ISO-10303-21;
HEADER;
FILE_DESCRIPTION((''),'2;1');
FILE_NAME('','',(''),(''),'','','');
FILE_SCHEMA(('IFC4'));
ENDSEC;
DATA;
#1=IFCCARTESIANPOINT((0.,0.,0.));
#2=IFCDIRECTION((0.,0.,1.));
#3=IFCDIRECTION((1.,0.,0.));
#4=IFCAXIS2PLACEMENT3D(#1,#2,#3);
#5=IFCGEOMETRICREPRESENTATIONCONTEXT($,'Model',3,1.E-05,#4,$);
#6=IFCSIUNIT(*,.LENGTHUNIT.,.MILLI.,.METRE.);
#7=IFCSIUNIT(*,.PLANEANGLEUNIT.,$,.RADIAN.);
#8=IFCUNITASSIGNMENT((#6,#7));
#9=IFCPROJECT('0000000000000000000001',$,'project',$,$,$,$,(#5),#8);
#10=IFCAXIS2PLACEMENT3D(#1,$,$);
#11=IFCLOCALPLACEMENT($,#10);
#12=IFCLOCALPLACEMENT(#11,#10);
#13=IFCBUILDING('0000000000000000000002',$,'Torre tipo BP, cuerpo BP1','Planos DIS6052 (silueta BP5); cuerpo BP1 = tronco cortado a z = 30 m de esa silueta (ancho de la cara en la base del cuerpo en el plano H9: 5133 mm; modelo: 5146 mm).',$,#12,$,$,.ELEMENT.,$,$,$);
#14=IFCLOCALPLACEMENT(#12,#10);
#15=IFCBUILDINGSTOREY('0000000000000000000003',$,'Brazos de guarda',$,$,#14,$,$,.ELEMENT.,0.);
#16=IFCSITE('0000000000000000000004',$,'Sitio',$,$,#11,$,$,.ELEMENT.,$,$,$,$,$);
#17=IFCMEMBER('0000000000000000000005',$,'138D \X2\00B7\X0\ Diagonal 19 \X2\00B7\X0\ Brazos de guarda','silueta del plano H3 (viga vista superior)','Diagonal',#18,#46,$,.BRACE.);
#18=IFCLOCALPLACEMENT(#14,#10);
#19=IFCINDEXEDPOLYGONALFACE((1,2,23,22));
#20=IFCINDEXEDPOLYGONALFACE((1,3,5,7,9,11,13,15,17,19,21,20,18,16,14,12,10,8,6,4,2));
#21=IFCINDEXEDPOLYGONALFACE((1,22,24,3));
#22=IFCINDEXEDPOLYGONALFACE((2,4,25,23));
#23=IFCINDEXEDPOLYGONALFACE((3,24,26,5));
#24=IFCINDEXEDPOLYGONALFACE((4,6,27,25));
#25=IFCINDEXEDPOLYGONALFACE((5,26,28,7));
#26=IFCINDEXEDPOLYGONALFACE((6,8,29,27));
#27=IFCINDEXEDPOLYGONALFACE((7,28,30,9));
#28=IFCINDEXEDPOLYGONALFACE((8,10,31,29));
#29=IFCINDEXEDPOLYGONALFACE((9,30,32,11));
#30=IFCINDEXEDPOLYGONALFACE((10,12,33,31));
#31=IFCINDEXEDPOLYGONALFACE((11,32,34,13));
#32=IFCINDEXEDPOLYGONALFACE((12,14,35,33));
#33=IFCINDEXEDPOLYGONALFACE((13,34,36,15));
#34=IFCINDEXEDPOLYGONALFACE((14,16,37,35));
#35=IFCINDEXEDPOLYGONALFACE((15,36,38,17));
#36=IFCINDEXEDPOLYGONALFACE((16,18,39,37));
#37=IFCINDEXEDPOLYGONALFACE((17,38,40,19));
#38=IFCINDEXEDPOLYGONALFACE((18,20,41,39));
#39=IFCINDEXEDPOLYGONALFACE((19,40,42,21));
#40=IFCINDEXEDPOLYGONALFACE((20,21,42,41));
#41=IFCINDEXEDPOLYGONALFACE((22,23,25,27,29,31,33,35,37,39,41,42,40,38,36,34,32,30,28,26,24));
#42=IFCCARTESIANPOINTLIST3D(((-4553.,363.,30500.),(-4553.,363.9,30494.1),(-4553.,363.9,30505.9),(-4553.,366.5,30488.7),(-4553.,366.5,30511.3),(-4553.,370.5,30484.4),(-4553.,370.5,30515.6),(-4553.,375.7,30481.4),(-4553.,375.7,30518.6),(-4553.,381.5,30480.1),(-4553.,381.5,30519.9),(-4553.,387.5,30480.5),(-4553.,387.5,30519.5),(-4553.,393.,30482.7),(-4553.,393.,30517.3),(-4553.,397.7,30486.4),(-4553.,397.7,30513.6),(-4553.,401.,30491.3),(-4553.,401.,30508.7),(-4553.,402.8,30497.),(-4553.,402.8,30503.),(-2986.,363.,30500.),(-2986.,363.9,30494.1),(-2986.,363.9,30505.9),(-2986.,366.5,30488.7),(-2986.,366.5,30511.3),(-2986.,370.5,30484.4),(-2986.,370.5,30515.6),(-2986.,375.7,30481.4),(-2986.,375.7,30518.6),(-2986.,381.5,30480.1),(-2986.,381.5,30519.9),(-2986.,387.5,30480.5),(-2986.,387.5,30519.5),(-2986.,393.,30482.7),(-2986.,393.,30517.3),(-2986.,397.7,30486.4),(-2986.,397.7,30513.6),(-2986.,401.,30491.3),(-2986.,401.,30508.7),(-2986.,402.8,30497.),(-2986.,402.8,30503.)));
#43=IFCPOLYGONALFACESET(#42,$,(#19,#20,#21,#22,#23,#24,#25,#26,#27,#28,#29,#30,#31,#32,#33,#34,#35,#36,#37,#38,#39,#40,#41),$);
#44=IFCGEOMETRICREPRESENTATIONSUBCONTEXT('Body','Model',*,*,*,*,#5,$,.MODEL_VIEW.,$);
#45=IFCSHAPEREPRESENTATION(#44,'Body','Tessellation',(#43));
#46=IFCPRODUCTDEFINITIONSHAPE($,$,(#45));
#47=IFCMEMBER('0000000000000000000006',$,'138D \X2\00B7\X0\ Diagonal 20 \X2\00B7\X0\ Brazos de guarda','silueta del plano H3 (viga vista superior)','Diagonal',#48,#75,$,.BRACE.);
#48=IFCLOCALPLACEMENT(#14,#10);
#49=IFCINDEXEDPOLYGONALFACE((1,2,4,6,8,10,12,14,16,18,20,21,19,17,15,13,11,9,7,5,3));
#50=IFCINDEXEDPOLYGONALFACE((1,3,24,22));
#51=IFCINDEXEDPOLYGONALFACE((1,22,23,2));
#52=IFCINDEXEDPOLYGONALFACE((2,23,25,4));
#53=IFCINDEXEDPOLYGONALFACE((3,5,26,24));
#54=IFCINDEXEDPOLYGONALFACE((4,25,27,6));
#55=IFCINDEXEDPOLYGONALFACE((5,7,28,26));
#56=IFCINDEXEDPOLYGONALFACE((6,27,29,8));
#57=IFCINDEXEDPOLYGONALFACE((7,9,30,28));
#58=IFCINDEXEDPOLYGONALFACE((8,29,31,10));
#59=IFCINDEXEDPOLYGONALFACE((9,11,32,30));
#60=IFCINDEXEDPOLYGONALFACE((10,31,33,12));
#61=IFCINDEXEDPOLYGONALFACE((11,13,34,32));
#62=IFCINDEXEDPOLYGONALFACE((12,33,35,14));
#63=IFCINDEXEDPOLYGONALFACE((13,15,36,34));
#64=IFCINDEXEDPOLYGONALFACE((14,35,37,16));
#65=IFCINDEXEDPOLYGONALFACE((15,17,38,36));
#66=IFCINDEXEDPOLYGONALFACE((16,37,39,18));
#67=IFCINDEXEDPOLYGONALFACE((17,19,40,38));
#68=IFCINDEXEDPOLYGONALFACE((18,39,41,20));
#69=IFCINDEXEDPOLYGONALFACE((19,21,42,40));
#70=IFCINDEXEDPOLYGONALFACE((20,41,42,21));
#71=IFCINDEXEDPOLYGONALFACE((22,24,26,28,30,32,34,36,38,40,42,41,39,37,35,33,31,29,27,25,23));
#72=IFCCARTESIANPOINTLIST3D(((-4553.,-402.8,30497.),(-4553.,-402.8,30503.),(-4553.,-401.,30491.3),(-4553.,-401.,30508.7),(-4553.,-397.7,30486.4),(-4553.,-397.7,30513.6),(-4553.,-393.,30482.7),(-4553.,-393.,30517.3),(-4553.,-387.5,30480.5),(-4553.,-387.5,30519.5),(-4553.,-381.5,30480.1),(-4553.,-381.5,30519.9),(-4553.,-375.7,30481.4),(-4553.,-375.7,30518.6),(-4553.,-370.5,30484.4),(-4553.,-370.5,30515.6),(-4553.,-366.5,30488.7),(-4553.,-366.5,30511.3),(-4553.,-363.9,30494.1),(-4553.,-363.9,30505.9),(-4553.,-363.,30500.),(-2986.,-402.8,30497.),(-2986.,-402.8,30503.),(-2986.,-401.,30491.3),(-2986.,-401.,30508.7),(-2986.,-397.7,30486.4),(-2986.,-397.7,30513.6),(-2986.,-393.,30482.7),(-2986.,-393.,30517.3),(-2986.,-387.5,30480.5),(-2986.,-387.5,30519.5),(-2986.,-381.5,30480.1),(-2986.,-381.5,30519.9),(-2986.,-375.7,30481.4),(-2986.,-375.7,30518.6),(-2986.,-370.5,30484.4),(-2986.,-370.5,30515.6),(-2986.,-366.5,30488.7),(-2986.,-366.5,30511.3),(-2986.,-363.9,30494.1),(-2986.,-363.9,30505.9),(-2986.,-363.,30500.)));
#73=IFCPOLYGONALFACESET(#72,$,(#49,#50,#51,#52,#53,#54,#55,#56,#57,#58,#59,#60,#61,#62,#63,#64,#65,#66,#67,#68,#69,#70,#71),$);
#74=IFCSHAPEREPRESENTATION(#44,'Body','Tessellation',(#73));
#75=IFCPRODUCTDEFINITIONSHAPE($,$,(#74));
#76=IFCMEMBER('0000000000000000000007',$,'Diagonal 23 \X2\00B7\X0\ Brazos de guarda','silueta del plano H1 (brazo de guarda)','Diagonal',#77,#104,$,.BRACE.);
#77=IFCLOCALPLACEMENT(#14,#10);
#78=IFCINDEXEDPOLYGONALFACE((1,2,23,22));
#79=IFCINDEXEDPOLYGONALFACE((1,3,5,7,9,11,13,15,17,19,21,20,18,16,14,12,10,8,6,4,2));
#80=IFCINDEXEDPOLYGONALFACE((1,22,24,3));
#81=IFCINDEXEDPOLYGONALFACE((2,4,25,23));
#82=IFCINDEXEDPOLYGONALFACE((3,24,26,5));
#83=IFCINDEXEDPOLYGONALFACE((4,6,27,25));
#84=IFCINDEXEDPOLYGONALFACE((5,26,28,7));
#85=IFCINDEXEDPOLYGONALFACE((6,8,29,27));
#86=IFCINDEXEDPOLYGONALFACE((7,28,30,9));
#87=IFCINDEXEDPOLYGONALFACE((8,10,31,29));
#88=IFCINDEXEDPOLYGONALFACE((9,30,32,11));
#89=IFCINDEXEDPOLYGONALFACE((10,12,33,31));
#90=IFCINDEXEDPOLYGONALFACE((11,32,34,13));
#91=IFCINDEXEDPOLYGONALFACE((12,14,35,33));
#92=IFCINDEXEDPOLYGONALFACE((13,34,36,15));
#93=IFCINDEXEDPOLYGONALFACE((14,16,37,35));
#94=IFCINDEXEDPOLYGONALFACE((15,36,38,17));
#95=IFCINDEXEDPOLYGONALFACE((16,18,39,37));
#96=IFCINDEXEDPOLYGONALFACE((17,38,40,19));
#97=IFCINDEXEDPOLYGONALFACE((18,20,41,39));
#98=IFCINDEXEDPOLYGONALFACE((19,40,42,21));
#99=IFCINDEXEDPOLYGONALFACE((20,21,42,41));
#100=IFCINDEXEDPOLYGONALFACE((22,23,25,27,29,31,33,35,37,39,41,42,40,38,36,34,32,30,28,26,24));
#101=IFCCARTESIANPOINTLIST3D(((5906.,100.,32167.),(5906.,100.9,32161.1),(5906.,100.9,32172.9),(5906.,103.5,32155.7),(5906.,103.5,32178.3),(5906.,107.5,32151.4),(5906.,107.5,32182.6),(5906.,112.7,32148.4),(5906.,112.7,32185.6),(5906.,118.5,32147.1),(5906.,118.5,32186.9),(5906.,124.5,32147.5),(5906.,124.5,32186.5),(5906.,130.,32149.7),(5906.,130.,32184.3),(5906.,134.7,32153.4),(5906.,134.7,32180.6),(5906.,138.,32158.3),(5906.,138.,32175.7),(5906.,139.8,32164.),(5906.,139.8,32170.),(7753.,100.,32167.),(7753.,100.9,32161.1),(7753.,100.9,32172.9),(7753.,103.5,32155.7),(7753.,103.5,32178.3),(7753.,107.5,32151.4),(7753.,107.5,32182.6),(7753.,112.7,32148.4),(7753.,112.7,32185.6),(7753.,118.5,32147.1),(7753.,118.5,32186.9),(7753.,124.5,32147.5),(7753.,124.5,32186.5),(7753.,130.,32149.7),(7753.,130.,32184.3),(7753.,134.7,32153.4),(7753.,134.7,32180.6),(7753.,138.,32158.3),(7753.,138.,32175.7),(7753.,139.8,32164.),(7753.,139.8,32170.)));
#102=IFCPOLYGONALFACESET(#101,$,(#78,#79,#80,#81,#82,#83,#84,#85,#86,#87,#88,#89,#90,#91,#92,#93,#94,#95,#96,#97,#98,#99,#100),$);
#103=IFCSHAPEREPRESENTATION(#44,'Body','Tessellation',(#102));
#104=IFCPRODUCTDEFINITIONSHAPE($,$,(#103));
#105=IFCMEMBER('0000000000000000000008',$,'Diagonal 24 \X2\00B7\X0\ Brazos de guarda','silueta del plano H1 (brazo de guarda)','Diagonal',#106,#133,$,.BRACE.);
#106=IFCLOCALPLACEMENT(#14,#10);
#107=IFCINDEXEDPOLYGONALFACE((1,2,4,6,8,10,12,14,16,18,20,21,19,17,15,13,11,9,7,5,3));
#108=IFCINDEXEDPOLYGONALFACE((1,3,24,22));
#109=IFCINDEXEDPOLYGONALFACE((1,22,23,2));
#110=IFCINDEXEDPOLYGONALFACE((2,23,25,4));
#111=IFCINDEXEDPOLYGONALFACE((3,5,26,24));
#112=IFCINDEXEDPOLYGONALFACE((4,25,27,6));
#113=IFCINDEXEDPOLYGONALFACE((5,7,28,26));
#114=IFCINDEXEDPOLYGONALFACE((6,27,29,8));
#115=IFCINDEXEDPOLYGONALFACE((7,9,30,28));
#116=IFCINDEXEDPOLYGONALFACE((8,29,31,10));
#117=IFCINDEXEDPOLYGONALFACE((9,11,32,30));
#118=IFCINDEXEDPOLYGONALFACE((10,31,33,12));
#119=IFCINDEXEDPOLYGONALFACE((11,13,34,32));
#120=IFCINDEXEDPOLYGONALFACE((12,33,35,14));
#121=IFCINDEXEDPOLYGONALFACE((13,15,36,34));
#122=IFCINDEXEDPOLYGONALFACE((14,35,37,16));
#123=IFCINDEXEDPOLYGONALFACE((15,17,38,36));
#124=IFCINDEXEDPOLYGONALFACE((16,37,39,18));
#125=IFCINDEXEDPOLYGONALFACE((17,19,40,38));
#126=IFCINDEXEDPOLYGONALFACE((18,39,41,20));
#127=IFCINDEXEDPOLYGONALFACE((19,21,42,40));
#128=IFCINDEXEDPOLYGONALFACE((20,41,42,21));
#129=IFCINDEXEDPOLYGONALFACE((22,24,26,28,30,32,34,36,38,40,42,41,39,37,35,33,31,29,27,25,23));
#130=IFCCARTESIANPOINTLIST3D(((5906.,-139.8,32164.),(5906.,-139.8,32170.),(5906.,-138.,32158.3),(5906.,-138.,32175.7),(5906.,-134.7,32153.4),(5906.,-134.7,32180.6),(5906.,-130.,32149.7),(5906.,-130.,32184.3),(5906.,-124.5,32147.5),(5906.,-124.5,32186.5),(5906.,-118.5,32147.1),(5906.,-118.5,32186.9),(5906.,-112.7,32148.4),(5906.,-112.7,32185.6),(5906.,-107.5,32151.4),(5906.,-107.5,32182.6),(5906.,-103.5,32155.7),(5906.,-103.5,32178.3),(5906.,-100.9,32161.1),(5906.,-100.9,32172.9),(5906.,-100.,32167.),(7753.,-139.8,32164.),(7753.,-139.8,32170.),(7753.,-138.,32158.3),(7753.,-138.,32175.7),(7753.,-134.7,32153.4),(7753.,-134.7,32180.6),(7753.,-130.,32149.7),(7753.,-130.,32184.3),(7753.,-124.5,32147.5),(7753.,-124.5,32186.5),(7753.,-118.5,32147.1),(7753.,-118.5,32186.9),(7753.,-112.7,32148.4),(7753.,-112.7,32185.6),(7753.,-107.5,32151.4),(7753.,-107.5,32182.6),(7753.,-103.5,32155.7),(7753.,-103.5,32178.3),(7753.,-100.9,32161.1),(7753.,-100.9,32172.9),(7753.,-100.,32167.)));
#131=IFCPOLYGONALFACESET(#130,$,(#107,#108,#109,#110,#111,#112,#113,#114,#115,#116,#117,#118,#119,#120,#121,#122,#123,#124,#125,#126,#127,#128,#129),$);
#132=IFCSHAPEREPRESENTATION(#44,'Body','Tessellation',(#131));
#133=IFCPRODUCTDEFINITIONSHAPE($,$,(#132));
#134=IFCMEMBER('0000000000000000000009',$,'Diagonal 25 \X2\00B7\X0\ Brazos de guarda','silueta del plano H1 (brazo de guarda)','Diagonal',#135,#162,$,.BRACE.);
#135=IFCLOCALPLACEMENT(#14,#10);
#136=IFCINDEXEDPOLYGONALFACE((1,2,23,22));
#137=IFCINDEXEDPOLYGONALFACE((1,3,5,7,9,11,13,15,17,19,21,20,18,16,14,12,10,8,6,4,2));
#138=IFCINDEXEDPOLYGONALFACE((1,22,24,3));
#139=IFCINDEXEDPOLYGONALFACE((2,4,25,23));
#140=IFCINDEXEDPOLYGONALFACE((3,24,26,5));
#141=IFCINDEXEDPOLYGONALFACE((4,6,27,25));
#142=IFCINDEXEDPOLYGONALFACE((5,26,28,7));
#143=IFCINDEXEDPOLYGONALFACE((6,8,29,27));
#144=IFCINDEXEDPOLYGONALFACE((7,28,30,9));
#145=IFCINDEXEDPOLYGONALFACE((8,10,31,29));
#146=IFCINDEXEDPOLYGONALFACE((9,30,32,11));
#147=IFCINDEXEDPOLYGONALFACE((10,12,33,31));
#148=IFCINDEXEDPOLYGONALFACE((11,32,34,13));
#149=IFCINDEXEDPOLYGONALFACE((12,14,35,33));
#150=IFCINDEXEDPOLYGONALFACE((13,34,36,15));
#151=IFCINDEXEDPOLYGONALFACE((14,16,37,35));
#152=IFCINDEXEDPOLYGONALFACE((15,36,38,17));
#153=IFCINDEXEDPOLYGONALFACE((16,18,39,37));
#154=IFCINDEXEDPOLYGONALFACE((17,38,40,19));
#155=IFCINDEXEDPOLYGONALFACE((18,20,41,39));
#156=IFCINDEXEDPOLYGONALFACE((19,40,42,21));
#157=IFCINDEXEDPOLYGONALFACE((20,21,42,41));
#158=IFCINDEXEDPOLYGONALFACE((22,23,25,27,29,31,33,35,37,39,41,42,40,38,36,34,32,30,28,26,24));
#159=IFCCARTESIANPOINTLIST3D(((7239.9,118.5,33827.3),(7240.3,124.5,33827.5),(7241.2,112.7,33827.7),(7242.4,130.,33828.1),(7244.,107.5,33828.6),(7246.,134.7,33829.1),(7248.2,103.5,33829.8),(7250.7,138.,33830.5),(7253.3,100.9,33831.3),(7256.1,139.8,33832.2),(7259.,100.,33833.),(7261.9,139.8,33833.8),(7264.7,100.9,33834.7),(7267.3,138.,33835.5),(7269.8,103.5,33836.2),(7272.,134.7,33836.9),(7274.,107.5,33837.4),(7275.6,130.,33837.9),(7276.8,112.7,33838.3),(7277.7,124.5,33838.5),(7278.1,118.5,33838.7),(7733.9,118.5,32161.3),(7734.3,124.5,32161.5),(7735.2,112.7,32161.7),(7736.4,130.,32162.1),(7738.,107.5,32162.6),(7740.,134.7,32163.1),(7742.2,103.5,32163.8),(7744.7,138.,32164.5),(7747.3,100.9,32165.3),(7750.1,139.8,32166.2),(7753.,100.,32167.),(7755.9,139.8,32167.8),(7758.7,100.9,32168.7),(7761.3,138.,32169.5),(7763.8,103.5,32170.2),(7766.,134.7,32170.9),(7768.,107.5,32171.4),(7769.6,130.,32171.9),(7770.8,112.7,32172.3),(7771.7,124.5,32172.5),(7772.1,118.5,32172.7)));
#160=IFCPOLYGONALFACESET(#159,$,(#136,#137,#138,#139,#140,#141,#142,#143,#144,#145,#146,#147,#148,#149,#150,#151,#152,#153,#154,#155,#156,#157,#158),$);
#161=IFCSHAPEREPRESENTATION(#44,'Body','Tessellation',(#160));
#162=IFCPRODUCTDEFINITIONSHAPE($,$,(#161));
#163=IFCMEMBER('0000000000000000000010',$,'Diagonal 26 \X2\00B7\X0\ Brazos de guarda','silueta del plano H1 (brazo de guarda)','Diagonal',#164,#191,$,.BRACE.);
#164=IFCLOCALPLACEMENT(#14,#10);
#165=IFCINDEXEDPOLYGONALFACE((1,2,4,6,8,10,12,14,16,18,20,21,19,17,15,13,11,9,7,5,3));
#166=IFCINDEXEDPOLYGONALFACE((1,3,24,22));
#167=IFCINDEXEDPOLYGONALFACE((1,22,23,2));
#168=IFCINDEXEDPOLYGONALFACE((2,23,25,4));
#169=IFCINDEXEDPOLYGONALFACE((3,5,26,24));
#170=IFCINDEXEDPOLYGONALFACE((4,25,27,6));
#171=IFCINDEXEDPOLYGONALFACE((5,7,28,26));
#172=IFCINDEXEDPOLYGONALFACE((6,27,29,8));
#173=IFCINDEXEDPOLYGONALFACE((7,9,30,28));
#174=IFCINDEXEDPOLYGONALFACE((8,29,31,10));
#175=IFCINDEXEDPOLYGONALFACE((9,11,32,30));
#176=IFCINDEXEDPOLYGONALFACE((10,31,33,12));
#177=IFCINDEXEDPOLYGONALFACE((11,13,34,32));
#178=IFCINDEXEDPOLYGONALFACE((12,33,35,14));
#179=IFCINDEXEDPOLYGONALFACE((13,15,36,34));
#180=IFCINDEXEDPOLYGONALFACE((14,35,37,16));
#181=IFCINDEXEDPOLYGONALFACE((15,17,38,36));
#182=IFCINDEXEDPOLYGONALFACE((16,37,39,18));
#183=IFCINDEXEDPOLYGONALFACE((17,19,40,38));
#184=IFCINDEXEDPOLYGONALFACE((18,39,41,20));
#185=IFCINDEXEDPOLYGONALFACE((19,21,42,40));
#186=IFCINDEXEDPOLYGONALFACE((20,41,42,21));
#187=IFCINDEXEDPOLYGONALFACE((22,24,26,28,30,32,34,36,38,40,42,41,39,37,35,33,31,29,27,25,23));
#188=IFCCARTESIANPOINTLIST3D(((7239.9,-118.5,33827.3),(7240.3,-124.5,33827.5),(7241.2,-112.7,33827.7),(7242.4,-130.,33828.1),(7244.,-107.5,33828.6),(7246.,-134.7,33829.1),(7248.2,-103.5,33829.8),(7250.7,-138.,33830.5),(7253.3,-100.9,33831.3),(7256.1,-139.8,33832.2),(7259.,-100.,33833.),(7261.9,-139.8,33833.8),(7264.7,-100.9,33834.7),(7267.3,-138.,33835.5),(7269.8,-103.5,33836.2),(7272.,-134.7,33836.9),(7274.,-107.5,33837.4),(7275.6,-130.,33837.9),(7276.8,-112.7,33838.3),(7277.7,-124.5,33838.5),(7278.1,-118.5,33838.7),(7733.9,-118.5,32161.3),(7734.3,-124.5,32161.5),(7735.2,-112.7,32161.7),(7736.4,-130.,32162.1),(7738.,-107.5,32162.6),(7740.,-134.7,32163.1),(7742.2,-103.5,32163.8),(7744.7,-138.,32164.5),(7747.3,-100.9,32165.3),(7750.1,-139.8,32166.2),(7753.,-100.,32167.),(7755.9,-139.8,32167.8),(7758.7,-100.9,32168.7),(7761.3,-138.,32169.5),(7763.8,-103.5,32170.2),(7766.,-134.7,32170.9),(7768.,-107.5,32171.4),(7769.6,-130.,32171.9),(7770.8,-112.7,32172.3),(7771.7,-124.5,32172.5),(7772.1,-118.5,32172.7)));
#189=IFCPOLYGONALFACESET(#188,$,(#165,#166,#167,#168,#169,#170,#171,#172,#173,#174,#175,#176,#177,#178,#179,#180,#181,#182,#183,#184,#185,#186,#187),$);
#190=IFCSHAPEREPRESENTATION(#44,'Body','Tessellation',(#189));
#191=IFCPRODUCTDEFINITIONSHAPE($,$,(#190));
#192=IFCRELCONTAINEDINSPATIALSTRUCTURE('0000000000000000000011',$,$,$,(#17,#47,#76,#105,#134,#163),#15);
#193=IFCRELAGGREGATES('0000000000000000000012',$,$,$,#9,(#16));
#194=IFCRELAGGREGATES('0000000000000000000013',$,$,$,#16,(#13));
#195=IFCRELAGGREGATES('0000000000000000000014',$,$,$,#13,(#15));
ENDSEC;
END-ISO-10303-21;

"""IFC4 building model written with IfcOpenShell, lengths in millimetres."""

from ifc_helpers import new_model, si_unit, frame, origin, origin_with_axes, place, context, subcontext, project, spatial, circle, extrude, element, save


model = new_model("IFC4")

# Units and contexts
model_context = context("Model", 3, precision=1e-05, world=origin_with_axes())
body_context = subcontext(model_context, "Body", "Model", "MODEL_VIEW")
ifc_project = project(units=[si_unit("LENGTHUNIT", "METRE", prefix="MILLI"), si_unit("PLANEANGLEUNIT", "RADIAN")], contexts=[model_context])

# Site, building, storey
site_placement = place(None, origin())
site = spatial("IfcSite", under=ifc_project, at=site_placement, Name="Sitio", CompositionType="ELEMENT")
building_placement = place(site_placement, origin())
building = spatial("IfcBuilding", under=site, at=building_placement, Name="Torre tipo BP, cuerpo BP1", Description="Planos DIS6052 (silueta BP5); cuerpo BP1 = tronco cortado a z = 30 m de esa silueta (ancho de la cara en la base del cuerpo en el plano H9: 5133 mm; modelo: 5146 mm).", CompositionType="ELEMENT")
storey_placement = place(building_placement, origin())
storey = spatial("IfcBuildingStorey", under=building, at=storey_placement, Name="Brazos de guarda", CompositionType="ELEMENT", Elevation=0.0)

# Members
for number, where, z_axis, x_axis, name in (
    (1, (-2986.0, 383.0, 30500.0), (-1.0, 0.0, 0.0), (0.0, -1.0, 0.0), "138D · Diagonal 19 · Brazos de guarda"),
    (2, (-2986.0, -383.0, 30500.0), (-1.0, 0.0, 0.0), (0.0, 1.0, 0.0), "138D · Diagonal 20 · Brazos de guarda"),
):
    element("IfcMember", number, at=place(storey_placement, frame(where, z_axis=z_axis, x_axis=x_axis)), inside=storey, Name=name, Description="silueta del plano H3 (viga vista superior)", ObjectType="Diagonal", PredefinedType="BRACE", context=body_context, shape_type="SweptSolid", body=[
        extrude(circle(Radius=20.0), None, (0.0, 0.0, 1.0), 1567.0),
    ])
for number, where, z_axis, x_axis, name in (
    (3, (5906.0, 120.0, 32167.0), (1.0, 0.0, 0.0), (0.0, -1.0, 0.0), "Diagonal 23 · Brazos de guarda"),
    (4, (5906.0, -120.0, 32167.0), (1.0, 0.0, 0.0), (0.0, 1.0, 0.0), "Diagonal 24 · Brazos de guarda"),
):
    element("IfcMember", number, at=place(storey_placement, frame(where, z_axis=z_axis, x_axis=x_axis)), inside=storey, Name=name, Description="silueta del plano H1 (brazo de guarda)", ObjectType="Diagonal", PredefinedType="BRACE", context=body_context, shape_type="SweptSolid", body=[
        extrude(circle(Radius=20.0), None, (0.0, 0.0, 1.0), 1847.0),
    ])
for number, where, z_axis, x_axis, name in (
    (5, (7753.0, 120.0, 32167.0), (-0.284284, 0.0, 0.95874), (0.0, -1.0, 0.0), "Diagonal 25 · Brazos de guarda"),
    (6, (7753.0, -120.0, 32167.0), (-0.284284, 0.0, 0.95874), (0.0, 1.0, 0.0), "Diagonal 26 · Brazos de guarda"),
):
    element("IfcMember", number, at=place(storey_placement, frame(where, z_axis=z_axis, x_axis=x_axis)), inside=storey, Name=name, Description="silueta del plano H1 (brazo de guarda)", ObjectType="Diagonal", PredefinedType="BRACE", context=body_context, shape_type="SweptSolid", body=[
        extrude(circle(Radius=20.0), None, (0.0, 0.0, 1.0), 1737.7),
    ])

save(model, "model.ifc")
